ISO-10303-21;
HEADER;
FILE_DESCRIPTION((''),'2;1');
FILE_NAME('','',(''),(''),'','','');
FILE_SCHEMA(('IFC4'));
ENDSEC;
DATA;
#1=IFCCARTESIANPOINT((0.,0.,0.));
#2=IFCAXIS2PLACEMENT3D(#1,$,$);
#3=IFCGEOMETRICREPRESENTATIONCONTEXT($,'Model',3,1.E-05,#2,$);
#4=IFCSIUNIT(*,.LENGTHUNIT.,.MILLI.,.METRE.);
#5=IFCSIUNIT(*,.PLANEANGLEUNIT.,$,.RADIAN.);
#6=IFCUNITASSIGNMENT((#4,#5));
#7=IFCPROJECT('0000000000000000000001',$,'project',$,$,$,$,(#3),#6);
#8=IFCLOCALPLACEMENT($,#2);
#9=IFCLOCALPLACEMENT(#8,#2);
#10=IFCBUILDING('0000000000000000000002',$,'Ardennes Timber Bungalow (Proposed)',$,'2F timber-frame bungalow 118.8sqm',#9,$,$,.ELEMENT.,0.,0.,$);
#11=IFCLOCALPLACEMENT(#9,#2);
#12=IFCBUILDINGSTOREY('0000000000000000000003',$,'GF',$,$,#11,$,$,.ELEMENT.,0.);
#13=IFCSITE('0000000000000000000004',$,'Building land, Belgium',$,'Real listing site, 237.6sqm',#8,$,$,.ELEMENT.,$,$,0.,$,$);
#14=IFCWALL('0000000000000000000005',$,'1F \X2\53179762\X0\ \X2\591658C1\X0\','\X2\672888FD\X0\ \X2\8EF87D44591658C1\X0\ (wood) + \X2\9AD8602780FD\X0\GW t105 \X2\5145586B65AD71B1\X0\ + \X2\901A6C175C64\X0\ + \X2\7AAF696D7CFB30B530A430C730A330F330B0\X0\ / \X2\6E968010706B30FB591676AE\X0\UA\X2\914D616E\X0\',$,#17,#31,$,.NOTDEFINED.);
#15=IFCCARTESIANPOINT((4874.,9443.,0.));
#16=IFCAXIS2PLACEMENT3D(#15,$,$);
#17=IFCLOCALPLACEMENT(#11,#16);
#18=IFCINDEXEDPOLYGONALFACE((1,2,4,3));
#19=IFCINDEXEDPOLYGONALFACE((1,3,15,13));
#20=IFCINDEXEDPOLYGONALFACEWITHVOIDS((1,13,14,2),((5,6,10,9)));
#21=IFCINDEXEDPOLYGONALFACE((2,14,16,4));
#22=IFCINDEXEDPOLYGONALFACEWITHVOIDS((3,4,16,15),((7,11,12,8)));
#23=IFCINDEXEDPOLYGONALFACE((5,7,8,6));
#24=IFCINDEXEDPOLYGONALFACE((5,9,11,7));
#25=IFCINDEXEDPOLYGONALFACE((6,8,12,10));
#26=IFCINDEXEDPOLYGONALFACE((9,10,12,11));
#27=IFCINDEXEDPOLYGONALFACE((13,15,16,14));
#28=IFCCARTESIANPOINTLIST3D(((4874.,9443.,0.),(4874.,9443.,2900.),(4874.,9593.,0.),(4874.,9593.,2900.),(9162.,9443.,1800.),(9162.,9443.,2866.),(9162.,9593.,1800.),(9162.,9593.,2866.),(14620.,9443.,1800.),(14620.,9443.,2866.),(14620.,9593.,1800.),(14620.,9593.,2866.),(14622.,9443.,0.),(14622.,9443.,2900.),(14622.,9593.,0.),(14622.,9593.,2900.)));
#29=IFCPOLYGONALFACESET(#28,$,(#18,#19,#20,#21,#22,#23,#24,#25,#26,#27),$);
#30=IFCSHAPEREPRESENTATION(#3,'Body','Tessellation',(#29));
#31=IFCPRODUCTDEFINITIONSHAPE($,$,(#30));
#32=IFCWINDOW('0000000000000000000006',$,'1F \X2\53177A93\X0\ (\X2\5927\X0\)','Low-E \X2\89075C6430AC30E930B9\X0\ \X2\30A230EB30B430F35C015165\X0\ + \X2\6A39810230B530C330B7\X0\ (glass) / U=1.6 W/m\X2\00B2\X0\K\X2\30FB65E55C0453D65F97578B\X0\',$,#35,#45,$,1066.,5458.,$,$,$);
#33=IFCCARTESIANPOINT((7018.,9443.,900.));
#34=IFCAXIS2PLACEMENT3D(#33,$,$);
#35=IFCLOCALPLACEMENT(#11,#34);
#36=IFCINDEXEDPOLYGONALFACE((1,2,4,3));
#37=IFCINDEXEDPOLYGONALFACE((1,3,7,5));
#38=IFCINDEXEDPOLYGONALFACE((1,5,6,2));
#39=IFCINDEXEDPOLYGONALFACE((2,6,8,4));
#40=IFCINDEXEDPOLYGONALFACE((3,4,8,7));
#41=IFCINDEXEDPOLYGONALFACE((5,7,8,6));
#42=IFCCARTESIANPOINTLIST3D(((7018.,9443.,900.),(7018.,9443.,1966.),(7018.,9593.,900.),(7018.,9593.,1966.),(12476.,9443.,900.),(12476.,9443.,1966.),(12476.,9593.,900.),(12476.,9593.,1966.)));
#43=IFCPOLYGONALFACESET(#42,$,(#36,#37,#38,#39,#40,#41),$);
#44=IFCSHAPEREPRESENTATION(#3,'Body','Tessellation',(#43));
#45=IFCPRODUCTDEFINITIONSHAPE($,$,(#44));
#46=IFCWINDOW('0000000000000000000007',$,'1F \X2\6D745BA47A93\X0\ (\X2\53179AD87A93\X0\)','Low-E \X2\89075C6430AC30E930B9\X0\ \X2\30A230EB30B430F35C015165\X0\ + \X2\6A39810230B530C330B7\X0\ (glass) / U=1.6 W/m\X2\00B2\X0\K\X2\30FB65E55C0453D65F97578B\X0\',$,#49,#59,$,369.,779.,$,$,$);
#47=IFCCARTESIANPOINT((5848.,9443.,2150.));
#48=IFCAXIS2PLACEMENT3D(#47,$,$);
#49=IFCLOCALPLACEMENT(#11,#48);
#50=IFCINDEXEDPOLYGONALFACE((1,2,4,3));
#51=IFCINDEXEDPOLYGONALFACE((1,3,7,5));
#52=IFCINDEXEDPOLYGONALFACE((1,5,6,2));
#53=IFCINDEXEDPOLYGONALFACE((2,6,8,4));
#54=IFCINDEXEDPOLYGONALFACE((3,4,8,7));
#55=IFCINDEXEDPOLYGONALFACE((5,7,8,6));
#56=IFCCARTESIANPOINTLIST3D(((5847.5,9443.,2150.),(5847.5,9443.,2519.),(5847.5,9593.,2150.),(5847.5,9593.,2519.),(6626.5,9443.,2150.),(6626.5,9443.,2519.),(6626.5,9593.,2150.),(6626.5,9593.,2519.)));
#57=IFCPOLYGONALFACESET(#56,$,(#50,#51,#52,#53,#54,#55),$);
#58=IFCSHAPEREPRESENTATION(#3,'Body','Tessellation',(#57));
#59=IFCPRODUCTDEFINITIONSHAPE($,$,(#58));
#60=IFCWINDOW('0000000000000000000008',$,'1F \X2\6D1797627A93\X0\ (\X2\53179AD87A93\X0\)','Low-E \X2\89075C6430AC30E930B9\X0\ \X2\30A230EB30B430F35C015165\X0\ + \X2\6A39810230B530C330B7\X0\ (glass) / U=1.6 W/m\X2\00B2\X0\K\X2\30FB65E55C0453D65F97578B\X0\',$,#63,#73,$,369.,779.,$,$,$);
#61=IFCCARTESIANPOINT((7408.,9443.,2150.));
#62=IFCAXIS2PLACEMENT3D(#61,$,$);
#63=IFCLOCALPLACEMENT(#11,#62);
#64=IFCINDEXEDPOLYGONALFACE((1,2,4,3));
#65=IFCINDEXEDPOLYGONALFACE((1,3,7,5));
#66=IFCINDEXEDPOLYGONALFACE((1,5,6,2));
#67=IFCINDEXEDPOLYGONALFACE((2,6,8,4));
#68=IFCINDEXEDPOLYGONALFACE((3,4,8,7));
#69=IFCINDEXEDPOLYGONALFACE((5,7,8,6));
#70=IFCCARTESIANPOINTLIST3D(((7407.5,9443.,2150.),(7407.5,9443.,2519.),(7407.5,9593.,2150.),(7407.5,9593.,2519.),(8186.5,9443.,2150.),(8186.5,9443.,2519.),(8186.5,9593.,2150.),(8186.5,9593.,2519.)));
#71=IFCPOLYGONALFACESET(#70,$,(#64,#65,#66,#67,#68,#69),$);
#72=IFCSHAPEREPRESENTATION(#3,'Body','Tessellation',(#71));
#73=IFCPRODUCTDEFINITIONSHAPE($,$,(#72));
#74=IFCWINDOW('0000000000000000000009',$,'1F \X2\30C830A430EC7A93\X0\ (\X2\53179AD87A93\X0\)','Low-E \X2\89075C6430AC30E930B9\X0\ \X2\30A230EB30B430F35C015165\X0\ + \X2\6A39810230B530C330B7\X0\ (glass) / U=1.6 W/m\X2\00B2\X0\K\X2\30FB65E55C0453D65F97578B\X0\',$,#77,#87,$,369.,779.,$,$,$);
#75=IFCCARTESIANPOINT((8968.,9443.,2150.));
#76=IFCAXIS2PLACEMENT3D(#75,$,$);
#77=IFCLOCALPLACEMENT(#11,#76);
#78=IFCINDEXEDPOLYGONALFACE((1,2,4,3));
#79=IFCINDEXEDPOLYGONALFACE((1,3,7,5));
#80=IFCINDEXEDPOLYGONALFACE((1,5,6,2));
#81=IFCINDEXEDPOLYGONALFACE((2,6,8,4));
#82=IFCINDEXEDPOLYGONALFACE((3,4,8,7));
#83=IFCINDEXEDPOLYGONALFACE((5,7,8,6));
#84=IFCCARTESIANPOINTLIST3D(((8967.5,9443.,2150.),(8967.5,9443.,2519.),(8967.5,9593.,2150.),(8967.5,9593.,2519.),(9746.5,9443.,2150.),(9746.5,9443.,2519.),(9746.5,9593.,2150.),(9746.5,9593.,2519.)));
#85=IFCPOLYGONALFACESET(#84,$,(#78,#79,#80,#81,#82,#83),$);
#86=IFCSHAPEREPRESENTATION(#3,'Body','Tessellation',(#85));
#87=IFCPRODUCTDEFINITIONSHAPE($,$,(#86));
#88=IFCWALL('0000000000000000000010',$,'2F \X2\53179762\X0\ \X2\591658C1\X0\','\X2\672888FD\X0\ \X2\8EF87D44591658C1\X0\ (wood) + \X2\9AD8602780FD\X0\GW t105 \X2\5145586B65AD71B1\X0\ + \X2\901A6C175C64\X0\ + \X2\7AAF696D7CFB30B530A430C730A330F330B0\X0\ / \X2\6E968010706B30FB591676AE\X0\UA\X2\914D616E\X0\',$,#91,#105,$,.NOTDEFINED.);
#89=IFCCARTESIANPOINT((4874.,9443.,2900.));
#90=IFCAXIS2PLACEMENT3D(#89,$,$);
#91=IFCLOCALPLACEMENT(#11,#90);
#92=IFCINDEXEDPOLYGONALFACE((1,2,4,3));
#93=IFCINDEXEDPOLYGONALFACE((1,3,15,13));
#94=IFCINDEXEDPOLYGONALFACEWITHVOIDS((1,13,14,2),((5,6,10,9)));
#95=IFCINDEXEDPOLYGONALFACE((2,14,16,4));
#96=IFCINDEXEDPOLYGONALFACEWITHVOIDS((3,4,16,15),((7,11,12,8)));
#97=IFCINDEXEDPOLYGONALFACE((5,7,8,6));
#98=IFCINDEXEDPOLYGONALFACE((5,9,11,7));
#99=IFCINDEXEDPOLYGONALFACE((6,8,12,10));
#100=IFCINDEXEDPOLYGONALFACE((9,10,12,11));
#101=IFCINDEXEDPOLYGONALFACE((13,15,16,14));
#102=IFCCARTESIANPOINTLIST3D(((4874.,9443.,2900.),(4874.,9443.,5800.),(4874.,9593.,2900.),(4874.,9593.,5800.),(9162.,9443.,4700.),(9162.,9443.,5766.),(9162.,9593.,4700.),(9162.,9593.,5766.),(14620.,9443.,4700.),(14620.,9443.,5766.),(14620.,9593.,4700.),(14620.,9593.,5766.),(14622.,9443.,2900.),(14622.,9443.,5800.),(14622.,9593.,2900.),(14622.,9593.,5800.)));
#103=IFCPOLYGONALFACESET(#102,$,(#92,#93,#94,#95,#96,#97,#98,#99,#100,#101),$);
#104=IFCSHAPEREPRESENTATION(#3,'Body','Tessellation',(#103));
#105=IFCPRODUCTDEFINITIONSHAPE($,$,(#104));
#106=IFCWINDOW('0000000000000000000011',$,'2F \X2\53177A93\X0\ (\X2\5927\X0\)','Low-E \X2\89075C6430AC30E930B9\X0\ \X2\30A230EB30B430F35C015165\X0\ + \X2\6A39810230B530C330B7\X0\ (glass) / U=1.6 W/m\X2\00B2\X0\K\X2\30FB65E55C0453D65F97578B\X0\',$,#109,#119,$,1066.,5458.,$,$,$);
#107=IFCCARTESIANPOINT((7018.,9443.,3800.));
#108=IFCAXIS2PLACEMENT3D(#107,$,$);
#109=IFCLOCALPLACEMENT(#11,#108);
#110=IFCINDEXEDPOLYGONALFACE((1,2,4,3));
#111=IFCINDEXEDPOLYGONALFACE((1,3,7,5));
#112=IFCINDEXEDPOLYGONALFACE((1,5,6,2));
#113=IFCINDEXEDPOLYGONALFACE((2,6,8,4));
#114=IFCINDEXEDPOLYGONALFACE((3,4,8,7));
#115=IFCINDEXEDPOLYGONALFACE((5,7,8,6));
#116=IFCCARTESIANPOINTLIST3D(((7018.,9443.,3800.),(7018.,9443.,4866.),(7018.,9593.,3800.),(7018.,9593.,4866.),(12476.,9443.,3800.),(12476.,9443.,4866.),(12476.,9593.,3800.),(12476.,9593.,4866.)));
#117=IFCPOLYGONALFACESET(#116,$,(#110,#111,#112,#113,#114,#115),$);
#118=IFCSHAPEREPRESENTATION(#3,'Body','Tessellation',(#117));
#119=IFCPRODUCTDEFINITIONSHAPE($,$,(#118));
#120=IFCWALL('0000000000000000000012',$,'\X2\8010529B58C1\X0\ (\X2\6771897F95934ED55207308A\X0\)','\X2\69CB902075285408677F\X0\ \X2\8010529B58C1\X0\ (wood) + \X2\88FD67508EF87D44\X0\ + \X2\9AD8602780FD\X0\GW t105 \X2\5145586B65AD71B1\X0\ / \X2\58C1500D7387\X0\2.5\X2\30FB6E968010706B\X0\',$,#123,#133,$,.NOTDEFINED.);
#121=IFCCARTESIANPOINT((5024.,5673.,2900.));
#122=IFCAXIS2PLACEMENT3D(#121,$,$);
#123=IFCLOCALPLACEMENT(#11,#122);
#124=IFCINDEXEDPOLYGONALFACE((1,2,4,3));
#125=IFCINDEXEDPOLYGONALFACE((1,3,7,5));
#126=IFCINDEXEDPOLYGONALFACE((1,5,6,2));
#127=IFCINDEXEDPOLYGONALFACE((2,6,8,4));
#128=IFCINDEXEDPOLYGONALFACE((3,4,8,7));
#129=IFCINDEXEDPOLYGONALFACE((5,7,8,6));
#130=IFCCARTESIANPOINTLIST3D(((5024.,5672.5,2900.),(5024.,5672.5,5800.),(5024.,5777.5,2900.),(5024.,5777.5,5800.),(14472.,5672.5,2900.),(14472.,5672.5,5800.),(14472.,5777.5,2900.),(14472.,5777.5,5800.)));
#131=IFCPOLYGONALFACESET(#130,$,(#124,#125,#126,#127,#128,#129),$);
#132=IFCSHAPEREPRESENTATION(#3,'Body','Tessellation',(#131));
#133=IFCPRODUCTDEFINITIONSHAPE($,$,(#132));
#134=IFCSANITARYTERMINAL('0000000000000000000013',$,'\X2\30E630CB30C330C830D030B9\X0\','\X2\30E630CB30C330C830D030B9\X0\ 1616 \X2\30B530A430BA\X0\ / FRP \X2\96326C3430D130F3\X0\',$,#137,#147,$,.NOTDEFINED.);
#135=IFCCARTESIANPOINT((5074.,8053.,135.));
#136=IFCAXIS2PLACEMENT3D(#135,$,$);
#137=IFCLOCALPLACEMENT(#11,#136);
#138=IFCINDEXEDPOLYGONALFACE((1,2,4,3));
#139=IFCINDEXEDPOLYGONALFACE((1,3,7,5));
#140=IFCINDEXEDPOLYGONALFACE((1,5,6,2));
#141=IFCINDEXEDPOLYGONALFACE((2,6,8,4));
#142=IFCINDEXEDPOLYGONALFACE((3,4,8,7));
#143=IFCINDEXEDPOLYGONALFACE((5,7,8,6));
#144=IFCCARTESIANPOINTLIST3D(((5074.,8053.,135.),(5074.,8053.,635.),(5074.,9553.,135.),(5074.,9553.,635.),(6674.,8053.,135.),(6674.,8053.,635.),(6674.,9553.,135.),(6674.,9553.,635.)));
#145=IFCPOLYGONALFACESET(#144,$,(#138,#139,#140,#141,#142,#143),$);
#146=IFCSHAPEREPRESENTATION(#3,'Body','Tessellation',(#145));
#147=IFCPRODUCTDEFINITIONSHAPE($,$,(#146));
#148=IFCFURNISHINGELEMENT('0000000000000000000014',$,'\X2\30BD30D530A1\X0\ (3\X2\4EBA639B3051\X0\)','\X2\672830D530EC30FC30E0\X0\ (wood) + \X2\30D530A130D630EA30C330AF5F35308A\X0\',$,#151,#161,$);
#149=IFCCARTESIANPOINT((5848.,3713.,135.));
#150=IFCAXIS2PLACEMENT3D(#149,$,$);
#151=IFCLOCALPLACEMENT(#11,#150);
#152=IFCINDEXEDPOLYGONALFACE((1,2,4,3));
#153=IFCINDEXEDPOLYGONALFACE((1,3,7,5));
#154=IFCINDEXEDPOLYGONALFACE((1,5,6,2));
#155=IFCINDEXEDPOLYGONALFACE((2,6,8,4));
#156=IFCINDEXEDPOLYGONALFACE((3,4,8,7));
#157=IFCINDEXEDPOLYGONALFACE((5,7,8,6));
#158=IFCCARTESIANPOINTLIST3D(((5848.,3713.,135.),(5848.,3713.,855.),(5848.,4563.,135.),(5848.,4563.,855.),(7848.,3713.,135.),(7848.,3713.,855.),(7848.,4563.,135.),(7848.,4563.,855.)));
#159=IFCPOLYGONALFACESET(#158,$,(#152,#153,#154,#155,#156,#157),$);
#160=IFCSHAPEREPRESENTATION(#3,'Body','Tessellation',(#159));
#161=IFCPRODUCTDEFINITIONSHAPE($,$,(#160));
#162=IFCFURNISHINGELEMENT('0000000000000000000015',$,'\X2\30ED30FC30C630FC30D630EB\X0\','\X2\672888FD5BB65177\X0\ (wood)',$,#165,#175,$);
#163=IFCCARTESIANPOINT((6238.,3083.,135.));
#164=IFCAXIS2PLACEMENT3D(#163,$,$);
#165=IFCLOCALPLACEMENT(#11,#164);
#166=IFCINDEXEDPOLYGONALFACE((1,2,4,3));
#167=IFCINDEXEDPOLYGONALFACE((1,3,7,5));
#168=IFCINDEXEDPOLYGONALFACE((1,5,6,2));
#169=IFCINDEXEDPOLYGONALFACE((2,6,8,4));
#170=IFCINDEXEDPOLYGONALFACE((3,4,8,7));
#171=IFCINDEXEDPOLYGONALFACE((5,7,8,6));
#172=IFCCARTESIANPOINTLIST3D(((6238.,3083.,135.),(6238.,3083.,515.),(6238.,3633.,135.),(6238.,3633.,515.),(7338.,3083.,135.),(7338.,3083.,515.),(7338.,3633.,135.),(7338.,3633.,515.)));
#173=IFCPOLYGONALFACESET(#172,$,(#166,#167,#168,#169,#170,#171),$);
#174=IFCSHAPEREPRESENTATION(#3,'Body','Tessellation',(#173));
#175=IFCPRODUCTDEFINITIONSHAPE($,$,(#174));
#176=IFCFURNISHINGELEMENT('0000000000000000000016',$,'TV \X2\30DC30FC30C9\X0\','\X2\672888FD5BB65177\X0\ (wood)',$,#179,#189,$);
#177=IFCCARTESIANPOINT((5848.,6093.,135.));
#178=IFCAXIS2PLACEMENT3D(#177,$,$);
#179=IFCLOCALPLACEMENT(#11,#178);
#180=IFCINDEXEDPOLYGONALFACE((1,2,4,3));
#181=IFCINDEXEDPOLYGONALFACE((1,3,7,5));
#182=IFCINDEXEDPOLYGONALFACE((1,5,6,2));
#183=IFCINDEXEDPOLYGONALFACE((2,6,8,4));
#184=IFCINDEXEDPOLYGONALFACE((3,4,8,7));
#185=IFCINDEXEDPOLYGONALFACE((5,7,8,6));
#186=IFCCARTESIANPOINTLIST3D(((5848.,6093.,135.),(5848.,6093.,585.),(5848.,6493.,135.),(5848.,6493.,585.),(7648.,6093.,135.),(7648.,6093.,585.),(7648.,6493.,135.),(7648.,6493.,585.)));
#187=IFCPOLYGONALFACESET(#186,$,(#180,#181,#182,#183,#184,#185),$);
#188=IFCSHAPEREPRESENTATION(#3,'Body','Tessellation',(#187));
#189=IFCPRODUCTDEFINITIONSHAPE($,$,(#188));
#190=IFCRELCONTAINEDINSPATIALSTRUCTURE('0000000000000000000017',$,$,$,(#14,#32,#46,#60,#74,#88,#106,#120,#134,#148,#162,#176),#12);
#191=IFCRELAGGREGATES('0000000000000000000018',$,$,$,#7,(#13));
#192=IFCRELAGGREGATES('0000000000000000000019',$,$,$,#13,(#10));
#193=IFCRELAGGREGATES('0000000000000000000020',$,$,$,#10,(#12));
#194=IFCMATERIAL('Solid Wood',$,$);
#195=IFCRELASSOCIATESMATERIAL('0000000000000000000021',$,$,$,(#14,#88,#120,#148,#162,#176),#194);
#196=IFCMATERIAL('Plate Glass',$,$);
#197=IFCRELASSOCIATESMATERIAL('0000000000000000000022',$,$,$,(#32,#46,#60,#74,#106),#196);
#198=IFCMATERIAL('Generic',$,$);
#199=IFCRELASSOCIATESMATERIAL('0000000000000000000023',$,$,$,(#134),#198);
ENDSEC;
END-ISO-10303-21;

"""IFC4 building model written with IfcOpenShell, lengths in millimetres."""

from ifc_helpers import new_model, si_unit, frame, frame_2d, origin, place, context, project, spatial, rectangle, extrude, material, element, fill, save


model = new_model("IFC4")

# Units and contexts
model_context = context("Model", 3, precision=1e-05, world=origin())
ifc_project = project(units=[si_unit("LENGTHUNIT", "METRE", prefix="MILLI"), si_unit("PLANEANGLEUNIT", "RADIAN")], contexts=[model_context])

# Site, building, storey
site_placement = place(None, origin())
site = spatial("IfcSite", under=ifc_project, at=site_placement, Name="Building land, Belgium", ObjectType="Real listing site, 237.6sqm", CompositionType="ELEMENT", RefElevation=0.0)
building_placement = place(site_placement, origin())
building = spatial("IfcBuilding", under=site, at=building_placement, Name="Ardennes Timber Bungalow (Proposed)", ObjectType="2F timber-frame bungalow 118.8sqm", CompositionType="ELEMENT", ElevationOfRefHeight=0.0, ElevationOfTerrain=0.0)
storey_placement = place(building_placement, origin())
storey = spatial("IfcBuildingStorey", under=building, at=storey_placement, Name="GF", CompositionType="ELEMENT", Elevation=0.0)

# Wall, openings, windows
ifc_material_1 = material(Name="Solid Wood")
wall_1_placement = place(storey_placement, frame((4874.0, 9443.0, 0.0)))
wall_1 = element("IfcWall", 1, at=wall_1_placement, inside=storey, material=ifc_material_1, Name="1F 北面 外壁", Description="木製 軸組外壁 (wood) + 高性能GW t105 充填断熱 + 通気層 + 窯業系サイディング / 準耐火・外皮UA配慮", PredefinedType="NOTDEFINED", context=model_context, shape_type="SweptSolid", body=[
    extrude(rectangle(XDim=9748.0, YDim=150.0, at=frame_2d((4874.0, 75.0))), frame((4874.0, 9443.0, 0.0)), (0.0, 0.0, 1.0), 2900.0),
])
opening_1_placement = place(storey_placement, frame((7018.0, 9443.0, 900.0)))
opening_1 = element("IfcOpeningElement", 2, at=opening_1_placement, cuts=wall_1, PredefinedType="NOTDEFINED", context=model_context, shape_type="SweptSolid", body=[
    extrude(rectangle(XDim=5458.0, YDim=150.0, at=frame_2d((2729.0, 75.0))), frame((7018.0, 9443.0, 900.0)), (0.0, 0.0, 1.0), 1066.0),
])
opening_2_placement = place(storey_placement, frame((5848.0, 9443.0, 2150.0)))
opening_2 = element("IfcOpeningElement", 3, at=opening_2_placement, cuts=wall_1, PredefinedType="NOTDEFINED", context=model_context, shape_type="SweptSolid", body=[
    extrude(rectangle(XDim=779.0, YDim=150.0, at=frame_2d((389.0, 75.0))), frame((5848.0, 9443.0, 2150.0)), (0.0, 0.0, 1.0), 369.0),
])
opening_3_placement = place(storey_placement, frame((7408.0, 9443.0, 2150.0)))
opening_3 = element("IfcOpeningElement", 4, at=opening_3_placement, cuts=wall_1, PredefinedType="NOTDEFINED", context=model_context, shape_type="SweptSolid", body=[
    extrude(rectangle(XDim=779.0, YDim=150.0, at=frame_2d((389.0, 75.0))), frame((7408.0, 9443.0, 2150.0)), (0.0, 0.0, 1.0), 369.0),
])
opening_4_placement = place(storey_placement, frame((8968.0, 9443.0, 2150.0)))
opening_4 = element("IfcOpeningElement", 5, at=opening_4_placement, cuts=wall_1, PredefinedType="NOTDEFINED", context=model_context, shape_type="SweptSolid", body=[
    extrude(rectangle(XDim=779.0, YDim=150.0, at=frame_2d((389.0, 75.0))), frame((8968.0, 9443.0, 2150.0)), (0.0, 0.0, 1.0), 369.0),
])
ifc_material_2 = material(Name="Plate Glass")
window_1_placement = place(storey_placement, frame((7018.0, 9443.0, 900.0)))
window_1 = element("IfcWindow", 6, at=window_1_placement, inside=storey, material=ifc_material_2, Name="1F 北窓 (大)", Description="Low-E 複層ガラス アルゴン封入 + 樹脂サッシ (glass) / U=1.6 W/m²K・日射取得型", OverallHeight=1066.0, OverallWidth=5458.0, context=model_context, shape_type="SweptSolid", body=[
    extrude(rectangle(XDim=5458.0, YDim=150.0, at=frame_2d((2729.0, 75.0))), frame((7018.0, 9443.0, 900.0)), (0.0, 0.0, 1.0), 1066.0),
])
fill(opening_1, window_1)
window_2_placement = place(storey_placement, frame((5848.0, 9443.0, 2150.0)))
window_2 = element("IfcWindow", 7, at=window_2_placement, inside=storey, material=ifc_material_2, Name="1F 浴室窓 (北高窓)", Description="Low-E 複層ガラス アルゴン封入 + 樹脂サッシ (glass) / U=1.6 W/m²K・日射取得型", OverallHeight=369.0, OverallWidth=779.0, context=model_context, shape_type="SweptSolid", body=[
    extrude(rectangle(XDim=779.0, YDim=150.0, at=frame_2d((389.0, 75.0))), frame((5848.0, 9443.0, 2150.0)), (0.0, 0.0, 1.0), 369.0),
])
fill(opening_2, window_2)
window_3_placement = place(storey_placement, frame((7408.0, 9443.0, 2150.0)))
window_3 = element("IfcWindow", 8, at=window_3_placement, inside=storey, material=ifc_material_2, Name="1F 洗面窓 (北高窓)", Description="Low-E 複層ガラス アルゴン封入 + 樹脂サッシ (glass) / U=1.6 W/m²K・日射取得型", OverallHeight=369.0, OverallWidth=779.0, context=model_context, shape_type="SweptSolid", body=[
    extrude(rectangle(XDim=779.0, YDim=150.0, at=frame_2d((389.0, 75.0))), frame((7408.0, 9443.0, 2150.0)), (0.0, 0.0, 1.0), 369.0),
])
fill(opening_3, window_3)
window_4_placement = place(storey_placement, frame((8968.0, 9443.0, 2150.0)))
window_4 = element("IfcWindow", 9, at=window_4_placement, inside=storey, material=ifc_material_2, Name="1F トイレ窓 (北高窓)", Description="Low-E 複層ガラス アルゴン封入 + 樹脂サッシ (glass) / U=1.6 W/m²K・日射取得型", OverallHeight=369.0, OverallWidth=779.0, context=model_context, shape_type="SweptSolid", body=[
    extrude(rectangle(XDim=779.0, YDim=150.0, at=frame_2d((389.0, 75.0))), frame((8968.0, 9443.0, 2150.0)), (0.0, 0.0, 1.0), 369.0),
])
fill(opening_4, window_4)

# Wall, opening, window
wall_2_placement = place(storey_placement, frame((4874.0, 9443.0, 2900.0)))
wall_2 = element("IfcWall", 10, at=wall_2_placement, inside=storey, material=ifc_material_1, Name="2F 北面 外壁", Description="木製 軸組外壁 (wood) + 高性能GW t105 充填断熱 + 通気層 + 窯業系サイディング / 準耐火・外皮UA配慮", PredefinedType="NOTDEFINED", context=model_context, shape_type="SweptSolid", body=[
    extrude(rectangle(XDim=9748.0, YDim=150.0, at=frame_2d((4874.0, 75.0))), frame((4874.0, 9443.0, 2900.0)), (0.0, 0.0, 1.0), 2900.0),
])
opening_5_placement = place(storey_placement, frame((7018.0, 9443.0, 3800.0)))
opening_5 = element("IfcOpeningElement", 11, at=opening_5_placement, cuts=wall_2, PredefinedType="NOTDEFINED", context=model_context, shape_type="SweptSolid", body=[
    extrude(rectangle(XDim=5458.0, YDim=150.0, at=frame_2d((2729.0, 75.0))), frame((7018.0, 9443.0, 3800.0)), (0.0, 0.0, 1.0), 1066.0),
])
window_5_placement = place(storey_placement, frame((7018.0, 9443.0, 3800.0)))
window_5 = element("IfcWindow", 12, at=window_5_placement, inside=storey, material=ifc_material_2, Name="2F 北窓 (大)", Description="Low-E 複層ガラス アルゴン封入 + 樹脂サッシ (glass) / U=1.6 W/m²K・日射取得型", OverallHeight=1066.0, OverallWidth=5458.0, context=model_context, shape_type="SweptSolid", body=[
    extrude(rectangle(XDim=5458.0, YDim=150.0, at=frame_2d((2729.0, 75.0))), frame((7018.0, 9443.0, 3800.0)), (0.0, 0.0, 1.0), 1066.0),
])
fill(opening_5, window_5)

# Wall
wall_3_placement = place(storey_placement, frame((5024.0, 5673.0, 2900.0)))
element("IfcWall", 13, at=wall_3_placement, inside=storey, material=ifc_material_1, Name="耐力壁 (東西間仕切り)", Description="構造用合板 耐力壁 (wood) + 製材軸組 + 高性能GW t105 充填断熱 / 壁倍率2.5・準耐火", PredefinedType="NOTDEFINED", context=model_context, shape_type="SweptSolid", body=[
    extrude(rectangle(XDim=9448.0, YDim=105.0, at=frame_2d((4724.0, 52.0))), frame((5024.0, 5673.0, 2900.0)), (0.0, 0.0, 1.0), 2900.0),
])

# Sanitary terminal
ifc_material_3 = material(Name="Generic")
sanitary_terminal_placement = place(storey_placement, frame((5074.0, 8053.0, 135.0)))
element("IfcSanitaryTerminal", 14, at=sanitary_terminal_placement, inside=storey, material=ifc_material_3, Name="ユニットバス", Description="ユニットバス 1616 サイズ / FRP 防水パン", PredefinedType="NOTDEFINED", context=model_context, shape_type="SweptSolid", body=[
    extrude(rectangle(XDim=1600.0, YDim=1500.0, at=frame_2d((800.0, 750.0))), frame((5074.0, 8053.0, 135.0)), (0.0, 0.0, 1.0), 500.0),
])

# Furnishing elements
furnishing_1_placement = place(storey_placement, frame((5848.0, 3713.0, 135.0)))
element("IfcFurnishingElement", 15, at=furnishing_1_placement, inside=storey, material=ifc_material_1, Name="ソファ (3人掛け)", Description="木フレーム (wood) + ファブリック張り", context=model_context, shape_type="SweptSolid", body=[
    extrude(rectangle(XDim=2000.0, YDim=850.0, at=frame_2d((1000.0, 425.0))), frame((5848.0, 3713.0, 135.0)), (0.0, 0.0, 1.0), 720.0),
])
furnishing_2_placement = place(storey_placement, frame((6238.0, 3083.0, 135.0)))
element("IfcFurnishingElement", 16, at=furnishing_2_placement, inside=storey, material=ifc_material_1, Name="ローテーブル", Description="木製家具 (wood)", context=model_context, shape_type="SweptSolid", body=[
    extrude(rectangle(XDim=1100.0, YDim=550.0, at=frame_2d((550.0, 275.0))), frame((6238.0, 3083.0, 135.0)), (0.0, 0.0, 1.0), 380.0),
])
furnishing_3_placement = place(storey_placement, frame((5848.0, 6093.0, 135.0)))
element("IfcFurnishingElement", 17, at=furnishing_3_placement, inside=storey, material=ifc_material_1, Name="TV ボード", Description="木製家具 (wood)", context=model_context, shape_type="SweptSolid", body=[
    extrude(rectangle(XDim=1800.0, YDim=400.0, at=frame_2d((900.0, 200.0))), frame((5848.0, 6093.0, 135.0)), (0.0, 0.0, 1.0), 450.0),
])

save(model, "model.ifc")
